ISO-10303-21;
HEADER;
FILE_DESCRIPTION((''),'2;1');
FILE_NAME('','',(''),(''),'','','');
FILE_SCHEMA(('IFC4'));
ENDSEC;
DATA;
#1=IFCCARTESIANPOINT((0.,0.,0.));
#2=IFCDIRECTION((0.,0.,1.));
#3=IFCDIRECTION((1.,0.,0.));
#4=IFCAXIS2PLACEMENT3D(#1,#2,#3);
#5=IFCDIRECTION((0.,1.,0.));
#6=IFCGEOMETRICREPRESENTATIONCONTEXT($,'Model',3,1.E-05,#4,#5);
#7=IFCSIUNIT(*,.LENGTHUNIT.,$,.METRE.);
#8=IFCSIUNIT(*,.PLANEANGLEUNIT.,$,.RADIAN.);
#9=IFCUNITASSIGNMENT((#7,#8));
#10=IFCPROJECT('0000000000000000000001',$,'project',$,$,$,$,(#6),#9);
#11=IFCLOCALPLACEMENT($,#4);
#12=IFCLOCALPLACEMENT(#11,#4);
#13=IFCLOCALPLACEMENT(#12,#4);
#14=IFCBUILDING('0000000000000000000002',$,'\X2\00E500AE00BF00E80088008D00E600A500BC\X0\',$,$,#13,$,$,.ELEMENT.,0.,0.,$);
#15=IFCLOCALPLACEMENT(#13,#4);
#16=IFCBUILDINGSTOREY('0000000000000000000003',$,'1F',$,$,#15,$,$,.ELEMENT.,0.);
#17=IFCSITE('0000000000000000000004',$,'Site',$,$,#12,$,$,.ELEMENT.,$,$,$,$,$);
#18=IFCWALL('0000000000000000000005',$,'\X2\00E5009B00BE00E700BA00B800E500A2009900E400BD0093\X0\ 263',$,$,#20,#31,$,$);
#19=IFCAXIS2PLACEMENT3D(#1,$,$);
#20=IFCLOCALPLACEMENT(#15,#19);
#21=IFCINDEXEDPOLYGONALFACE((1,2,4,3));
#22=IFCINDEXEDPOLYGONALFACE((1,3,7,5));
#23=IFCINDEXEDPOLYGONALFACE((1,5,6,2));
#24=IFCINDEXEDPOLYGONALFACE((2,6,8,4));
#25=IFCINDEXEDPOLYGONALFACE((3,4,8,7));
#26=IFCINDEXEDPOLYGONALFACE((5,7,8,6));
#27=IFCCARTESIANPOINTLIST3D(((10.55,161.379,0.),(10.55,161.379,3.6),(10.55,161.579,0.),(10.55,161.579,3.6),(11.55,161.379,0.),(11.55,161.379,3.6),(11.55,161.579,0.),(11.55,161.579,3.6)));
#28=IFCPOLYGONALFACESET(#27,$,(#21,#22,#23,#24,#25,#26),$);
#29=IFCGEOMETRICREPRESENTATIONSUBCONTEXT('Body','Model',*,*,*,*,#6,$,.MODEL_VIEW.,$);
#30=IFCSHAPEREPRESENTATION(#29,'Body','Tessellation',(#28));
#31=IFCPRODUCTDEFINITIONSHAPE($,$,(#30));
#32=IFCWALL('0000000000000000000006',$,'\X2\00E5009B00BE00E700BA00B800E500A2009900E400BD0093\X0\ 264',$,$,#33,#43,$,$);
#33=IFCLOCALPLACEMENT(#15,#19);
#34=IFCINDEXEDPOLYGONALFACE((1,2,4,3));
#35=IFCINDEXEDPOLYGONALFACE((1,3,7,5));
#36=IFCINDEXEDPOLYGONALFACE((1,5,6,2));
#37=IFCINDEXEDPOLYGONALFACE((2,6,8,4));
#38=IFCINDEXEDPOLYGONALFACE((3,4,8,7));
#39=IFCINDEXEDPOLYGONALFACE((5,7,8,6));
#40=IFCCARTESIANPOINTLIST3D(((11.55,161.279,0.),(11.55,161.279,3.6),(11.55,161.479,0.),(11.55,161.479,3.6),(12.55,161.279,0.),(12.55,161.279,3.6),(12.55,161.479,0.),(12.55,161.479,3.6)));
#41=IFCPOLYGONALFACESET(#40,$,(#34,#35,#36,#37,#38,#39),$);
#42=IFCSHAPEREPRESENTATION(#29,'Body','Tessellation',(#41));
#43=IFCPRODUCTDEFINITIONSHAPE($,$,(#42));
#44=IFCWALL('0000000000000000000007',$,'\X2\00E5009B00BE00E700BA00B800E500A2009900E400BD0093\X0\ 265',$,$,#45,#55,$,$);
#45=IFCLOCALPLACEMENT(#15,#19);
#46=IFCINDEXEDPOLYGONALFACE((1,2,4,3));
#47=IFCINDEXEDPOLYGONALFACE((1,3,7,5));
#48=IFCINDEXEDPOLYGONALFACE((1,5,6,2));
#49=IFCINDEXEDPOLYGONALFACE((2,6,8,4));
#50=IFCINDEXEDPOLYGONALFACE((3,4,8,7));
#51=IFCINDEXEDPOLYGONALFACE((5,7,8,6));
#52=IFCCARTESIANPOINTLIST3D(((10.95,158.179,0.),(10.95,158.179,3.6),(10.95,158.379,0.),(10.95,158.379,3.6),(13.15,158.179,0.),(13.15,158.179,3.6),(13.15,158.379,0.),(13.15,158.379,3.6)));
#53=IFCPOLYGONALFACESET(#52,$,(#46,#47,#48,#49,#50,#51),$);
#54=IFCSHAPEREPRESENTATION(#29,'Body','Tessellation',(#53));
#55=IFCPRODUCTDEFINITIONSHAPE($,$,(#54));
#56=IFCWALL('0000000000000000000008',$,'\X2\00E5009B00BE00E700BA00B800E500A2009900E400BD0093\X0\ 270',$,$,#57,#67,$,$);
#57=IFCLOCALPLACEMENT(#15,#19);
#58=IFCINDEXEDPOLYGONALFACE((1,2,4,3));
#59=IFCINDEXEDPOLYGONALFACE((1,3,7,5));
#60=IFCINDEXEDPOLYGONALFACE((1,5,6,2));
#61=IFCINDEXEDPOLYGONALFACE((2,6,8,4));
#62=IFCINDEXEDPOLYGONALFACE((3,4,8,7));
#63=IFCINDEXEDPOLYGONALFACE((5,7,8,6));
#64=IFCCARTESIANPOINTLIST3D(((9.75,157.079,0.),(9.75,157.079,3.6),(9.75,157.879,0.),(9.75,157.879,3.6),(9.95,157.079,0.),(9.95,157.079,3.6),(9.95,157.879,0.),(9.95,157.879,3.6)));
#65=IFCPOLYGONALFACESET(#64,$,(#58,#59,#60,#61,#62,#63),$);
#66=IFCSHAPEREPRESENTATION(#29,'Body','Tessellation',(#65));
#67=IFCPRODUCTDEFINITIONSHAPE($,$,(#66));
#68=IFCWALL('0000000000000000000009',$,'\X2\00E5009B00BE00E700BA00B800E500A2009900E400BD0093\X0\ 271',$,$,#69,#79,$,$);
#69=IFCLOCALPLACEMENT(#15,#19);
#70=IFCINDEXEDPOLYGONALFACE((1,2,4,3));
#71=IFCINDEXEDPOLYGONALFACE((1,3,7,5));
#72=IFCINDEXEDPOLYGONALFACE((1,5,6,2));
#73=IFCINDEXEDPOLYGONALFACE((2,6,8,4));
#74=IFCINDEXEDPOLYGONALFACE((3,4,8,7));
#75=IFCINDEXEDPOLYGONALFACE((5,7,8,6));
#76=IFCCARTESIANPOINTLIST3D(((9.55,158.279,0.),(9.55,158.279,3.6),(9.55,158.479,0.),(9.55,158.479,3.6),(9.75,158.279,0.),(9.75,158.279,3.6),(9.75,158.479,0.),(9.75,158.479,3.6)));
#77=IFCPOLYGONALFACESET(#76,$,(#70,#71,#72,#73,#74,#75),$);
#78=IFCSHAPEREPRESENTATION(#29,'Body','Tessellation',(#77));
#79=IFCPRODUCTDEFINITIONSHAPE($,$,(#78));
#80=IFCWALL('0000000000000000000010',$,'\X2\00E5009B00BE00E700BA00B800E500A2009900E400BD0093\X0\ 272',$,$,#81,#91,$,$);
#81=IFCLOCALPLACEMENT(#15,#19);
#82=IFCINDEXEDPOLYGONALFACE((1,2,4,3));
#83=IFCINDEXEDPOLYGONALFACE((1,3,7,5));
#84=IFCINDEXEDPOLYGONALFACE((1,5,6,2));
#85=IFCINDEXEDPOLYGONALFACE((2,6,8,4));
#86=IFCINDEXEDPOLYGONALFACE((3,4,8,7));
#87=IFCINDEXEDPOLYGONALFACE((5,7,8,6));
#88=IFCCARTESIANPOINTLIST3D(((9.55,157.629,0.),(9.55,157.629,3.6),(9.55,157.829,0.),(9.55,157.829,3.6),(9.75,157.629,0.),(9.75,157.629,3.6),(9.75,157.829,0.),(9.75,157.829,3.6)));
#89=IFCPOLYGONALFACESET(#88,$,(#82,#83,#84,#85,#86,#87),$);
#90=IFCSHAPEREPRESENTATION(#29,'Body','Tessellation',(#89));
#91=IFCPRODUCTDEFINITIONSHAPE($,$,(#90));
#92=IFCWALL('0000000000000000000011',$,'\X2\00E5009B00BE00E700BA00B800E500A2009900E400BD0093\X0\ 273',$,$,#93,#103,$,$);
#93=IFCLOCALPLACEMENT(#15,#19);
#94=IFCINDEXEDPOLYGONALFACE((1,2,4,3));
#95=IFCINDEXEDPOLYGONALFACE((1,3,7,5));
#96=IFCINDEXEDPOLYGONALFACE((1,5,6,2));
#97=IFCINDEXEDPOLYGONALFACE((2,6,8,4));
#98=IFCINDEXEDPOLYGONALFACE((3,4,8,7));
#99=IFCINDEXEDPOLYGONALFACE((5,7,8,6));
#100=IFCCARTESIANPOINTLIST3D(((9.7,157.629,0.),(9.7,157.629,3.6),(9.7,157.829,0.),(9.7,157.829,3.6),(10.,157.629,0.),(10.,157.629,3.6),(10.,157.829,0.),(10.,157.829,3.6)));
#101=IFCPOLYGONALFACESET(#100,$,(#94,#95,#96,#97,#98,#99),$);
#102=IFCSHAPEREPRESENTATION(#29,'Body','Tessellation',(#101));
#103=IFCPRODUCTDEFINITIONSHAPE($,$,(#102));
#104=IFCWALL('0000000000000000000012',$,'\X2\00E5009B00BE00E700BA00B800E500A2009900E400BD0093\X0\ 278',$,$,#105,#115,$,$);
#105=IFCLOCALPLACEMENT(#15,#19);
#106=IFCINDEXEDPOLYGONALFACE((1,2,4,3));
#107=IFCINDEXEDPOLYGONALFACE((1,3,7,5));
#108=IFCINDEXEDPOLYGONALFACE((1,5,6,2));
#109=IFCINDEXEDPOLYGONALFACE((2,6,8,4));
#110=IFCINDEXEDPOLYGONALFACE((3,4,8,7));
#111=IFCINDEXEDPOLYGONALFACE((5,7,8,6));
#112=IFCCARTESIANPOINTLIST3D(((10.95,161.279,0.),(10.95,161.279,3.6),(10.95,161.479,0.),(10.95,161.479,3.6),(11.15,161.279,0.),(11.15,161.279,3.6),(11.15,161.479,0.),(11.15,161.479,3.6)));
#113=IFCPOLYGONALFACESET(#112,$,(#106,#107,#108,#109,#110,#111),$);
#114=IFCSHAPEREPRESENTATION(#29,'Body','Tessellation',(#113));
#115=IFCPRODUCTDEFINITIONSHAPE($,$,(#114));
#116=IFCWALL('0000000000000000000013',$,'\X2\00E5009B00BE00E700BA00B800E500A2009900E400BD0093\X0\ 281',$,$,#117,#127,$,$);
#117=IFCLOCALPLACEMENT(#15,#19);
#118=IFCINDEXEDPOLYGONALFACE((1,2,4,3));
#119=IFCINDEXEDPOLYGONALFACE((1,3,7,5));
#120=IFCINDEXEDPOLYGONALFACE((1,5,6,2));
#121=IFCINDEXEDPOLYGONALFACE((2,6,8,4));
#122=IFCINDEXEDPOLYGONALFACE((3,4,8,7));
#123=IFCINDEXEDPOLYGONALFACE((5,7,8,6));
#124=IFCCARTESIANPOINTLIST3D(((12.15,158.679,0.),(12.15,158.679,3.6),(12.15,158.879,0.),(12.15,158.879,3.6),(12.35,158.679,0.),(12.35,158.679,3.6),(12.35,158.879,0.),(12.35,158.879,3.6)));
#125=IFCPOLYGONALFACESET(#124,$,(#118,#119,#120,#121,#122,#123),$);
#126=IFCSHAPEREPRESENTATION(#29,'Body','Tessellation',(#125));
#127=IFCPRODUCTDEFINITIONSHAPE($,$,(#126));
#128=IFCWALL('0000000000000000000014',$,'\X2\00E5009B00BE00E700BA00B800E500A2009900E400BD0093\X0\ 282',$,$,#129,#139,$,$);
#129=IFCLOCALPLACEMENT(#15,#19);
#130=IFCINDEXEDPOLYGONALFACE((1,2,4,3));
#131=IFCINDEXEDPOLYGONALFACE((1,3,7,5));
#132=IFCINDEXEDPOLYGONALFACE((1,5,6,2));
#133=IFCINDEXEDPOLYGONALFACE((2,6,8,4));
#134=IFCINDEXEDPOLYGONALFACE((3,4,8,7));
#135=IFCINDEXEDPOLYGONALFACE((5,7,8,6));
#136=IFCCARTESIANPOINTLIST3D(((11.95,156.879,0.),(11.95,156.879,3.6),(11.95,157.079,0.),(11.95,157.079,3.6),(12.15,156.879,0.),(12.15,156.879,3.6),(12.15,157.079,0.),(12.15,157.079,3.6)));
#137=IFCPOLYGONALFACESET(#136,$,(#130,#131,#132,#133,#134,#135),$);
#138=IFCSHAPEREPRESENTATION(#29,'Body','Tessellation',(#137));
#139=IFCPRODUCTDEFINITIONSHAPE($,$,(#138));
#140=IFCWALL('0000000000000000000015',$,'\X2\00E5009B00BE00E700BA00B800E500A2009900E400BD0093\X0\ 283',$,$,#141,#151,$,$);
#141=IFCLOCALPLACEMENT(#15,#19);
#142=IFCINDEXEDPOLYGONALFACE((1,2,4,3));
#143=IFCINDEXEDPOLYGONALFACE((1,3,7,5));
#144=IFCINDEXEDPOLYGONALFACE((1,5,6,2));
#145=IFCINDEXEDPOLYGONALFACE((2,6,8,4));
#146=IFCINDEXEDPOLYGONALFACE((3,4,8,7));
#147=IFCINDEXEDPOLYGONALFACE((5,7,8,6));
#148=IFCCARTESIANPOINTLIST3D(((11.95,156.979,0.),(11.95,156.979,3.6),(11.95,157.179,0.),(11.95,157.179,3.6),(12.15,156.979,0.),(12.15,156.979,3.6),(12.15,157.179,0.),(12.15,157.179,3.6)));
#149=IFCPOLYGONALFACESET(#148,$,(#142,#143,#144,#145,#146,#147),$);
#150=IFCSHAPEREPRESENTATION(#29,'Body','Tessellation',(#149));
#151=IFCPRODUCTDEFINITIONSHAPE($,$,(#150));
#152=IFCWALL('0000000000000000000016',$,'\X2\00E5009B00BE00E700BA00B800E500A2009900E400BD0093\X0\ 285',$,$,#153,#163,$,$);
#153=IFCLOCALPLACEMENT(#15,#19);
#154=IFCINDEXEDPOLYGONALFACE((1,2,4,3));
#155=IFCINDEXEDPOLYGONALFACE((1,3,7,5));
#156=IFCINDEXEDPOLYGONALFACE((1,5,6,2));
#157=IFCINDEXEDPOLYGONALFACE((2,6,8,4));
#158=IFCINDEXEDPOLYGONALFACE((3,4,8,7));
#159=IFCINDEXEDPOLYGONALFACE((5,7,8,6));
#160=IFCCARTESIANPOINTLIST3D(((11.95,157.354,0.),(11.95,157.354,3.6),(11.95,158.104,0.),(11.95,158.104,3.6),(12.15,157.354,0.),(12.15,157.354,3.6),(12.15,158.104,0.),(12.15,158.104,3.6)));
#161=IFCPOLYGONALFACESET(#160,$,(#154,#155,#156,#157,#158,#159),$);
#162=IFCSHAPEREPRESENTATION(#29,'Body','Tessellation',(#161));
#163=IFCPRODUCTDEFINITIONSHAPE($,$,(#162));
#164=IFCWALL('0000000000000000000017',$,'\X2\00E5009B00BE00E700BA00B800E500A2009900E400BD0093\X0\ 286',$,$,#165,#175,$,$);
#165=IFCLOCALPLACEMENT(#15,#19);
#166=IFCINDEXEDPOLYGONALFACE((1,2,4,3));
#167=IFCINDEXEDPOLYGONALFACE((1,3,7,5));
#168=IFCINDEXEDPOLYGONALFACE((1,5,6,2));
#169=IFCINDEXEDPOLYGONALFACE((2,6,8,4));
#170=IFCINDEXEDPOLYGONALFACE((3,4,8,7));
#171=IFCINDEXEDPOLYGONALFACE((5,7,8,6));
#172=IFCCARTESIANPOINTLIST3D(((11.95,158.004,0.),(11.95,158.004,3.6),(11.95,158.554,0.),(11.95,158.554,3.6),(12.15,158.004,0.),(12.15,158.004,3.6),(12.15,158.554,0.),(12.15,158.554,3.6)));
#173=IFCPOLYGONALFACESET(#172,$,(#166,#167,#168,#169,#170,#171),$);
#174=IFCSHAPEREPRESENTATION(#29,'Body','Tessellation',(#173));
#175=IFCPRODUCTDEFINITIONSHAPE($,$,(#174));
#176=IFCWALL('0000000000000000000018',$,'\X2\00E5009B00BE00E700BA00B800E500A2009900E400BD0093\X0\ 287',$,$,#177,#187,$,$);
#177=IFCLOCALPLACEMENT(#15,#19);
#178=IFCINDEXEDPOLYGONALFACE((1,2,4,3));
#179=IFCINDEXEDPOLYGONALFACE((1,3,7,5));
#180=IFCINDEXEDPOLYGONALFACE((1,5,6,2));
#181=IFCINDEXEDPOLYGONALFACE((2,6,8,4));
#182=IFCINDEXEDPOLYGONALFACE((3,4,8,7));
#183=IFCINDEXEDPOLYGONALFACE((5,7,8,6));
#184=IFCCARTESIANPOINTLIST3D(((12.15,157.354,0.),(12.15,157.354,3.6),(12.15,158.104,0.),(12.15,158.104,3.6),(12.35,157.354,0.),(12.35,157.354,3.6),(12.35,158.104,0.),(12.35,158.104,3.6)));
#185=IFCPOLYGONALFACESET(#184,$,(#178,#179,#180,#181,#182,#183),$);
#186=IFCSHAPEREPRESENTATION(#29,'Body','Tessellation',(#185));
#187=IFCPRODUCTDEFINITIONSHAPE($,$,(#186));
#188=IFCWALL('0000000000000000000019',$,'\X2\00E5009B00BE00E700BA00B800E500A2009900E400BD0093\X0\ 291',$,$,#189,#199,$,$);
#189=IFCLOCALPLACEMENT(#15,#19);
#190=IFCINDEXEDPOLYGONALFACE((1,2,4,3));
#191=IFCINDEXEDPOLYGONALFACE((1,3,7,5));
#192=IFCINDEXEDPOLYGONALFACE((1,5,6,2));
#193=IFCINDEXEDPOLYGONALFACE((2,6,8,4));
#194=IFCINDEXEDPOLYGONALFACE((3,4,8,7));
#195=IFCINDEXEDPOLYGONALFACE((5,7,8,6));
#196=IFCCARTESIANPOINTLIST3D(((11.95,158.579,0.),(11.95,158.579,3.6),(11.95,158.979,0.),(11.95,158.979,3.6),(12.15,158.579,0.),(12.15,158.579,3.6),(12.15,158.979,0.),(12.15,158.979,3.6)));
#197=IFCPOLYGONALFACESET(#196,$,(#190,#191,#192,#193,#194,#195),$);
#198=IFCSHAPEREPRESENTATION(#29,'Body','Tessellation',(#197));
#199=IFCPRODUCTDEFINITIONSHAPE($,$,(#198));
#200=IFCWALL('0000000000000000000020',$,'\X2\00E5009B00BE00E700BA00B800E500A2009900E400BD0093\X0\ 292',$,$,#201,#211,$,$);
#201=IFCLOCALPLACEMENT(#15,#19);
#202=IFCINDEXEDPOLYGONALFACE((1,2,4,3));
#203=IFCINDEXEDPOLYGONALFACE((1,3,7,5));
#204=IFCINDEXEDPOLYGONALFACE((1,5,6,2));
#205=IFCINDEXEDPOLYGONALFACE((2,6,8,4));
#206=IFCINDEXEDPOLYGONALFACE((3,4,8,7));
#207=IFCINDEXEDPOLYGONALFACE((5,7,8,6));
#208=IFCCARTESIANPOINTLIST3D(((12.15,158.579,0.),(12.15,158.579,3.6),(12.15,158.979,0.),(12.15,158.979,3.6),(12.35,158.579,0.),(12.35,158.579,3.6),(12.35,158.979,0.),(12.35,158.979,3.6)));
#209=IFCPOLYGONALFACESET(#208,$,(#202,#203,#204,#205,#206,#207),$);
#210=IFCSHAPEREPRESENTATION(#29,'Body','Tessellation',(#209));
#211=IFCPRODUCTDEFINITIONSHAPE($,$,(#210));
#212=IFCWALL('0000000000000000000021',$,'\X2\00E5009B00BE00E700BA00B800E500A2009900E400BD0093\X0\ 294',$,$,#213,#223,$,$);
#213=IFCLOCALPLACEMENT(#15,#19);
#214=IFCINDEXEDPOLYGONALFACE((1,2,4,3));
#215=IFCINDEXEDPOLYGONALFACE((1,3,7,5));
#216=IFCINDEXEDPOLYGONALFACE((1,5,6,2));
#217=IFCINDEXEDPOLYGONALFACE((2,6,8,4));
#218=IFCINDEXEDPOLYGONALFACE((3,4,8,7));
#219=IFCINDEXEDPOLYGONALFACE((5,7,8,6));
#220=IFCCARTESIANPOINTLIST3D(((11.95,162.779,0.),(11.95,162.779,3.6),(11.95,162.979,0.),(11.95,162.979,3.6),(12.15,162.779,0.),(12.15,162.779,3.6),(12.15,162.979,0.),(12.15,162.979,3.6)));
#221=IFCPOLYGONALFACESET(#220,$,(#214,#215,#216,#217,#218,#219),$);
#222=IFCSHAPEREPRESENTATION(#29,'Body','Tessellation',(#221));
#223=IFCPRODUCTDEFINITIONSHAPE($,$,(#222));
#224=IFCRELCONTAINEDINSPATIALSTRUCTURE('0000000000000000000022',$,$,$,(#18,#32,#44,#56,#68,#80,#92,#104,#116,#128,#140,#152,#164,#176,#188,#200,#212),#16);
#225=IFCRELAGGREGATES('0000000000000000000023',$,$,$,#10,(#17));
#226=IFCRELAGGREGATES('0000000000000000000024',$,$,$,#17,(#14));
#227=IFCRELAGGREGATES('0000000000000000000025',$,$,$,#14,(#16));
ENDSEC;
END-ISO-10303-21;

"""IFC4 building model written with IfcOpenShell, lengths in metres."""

from ifc_helpers import new_model, si_unit, direction, frame, frame_2d, origin_with_axes, place, context, subcontext, project, spatial, rectangle, extrude, element, save


model = new_model("IFC4")

# Units and contexts
model_context = context("Model", 3, precision=1e-05, world=origin_with_axes(), true_north=direction((0.0, 1.0, 0.0)))
body_context = subcontext(model_context, "Body", "Model", "MODEL_VIEW")
ifc_project = project(units=[si_unit("LENGTHUNIT", "METRE"), si_unit("PLANEANGLEUNIT", "RADIAN")], contexts=[model_context])

# Site, building, storey
placement = place(None, origin_with_axes())
site_placement = place(placement, origin_with_axes())
site = spatial("IfcSite", under=ifc_project, at=site_placement, Name="Site", CompositionType="ELEMENT")
building_placement = place(site_placement, origin_with_axes())
building = spatial("IfcBuilding", under=site, at=building_placement, Name="å®¿è\u0088\u008dæ¥¼", CompositionType="ELEMENT", ElevationOfRefHeight=0.0, ElevationOfTerrain=0.0)
storey_placement = place(building_placement, origin_with_axes())
storey = spatial("IfcBuildingStorey", under=building, at=storey_placement, Name="1F", CompositionType="ELEMENT", Elevation=0.0)

# Walls
for number, where, z_axis, x_axis, name in (
    (1, (11.05, 161.479, 0.0), (0.0, 0.0, 1.0), (1.0, 0.0, 0.0), "å\u009b¾çº¸å¢\u0099ä½\u0093 263"),
    (2, (12.05, 161.379, 0.0), (0.0, 0.0, 1.0), (-1.0, 0.0, 0.0), "å\u009b¾çº¸å¢\u0099ä½\u0093 264"),
):
    element("IfcWall", number, at=place(storey_placement, frame(where, z_axis=z_axis, x_axis=x_axis)), inside=storey, Name=name, context=body_context, shape_type="SweptSolid", body=[
        extrude(rectangle(XDim=1.0, YDim=0.2, at=frame_2d((0.0, 0.0), x_axis=(1.0, 0.0, 0.0))), frame((0.0, 0.0, 0.0), z_axis=(0.0, 0.0, 1.0)), (0.0, 0.0, 1.0), 3.6),
    ])
wall_1_placement = place(storey_placement, frame((12.05, 158.279, 0.0), z_axis=(0.0, 0.0, 1.0), x_axis=(-1.0, 0.0, 0.0)))
element("IfcWall", 3, at=wall_1_placement, inside=storey, Name="å\u009b¾çº¸å¢\u0099ä½\u0093 265", context=body_context, shape_type="SweptSolid", body=[
    extrude(rectangle(XDim=2.2, YDim=0.2, at=frame_2d((0.0, 0.0), x_axis=(1.0, 0.0, 0.0))), frame((0.0, 0.0, 0.0), z_axis=(0.0, 0.0, 1.0)), (0.0, 0.0, 1.0), 3.6),
])
wall_2_placement = place(storey_placement, frame((9.85, 157.479, 0.0), z_axis=(0.0, 0.0, 1.0), x_axis=(0.0, 1.0, 0.0)))
element("IfcWall", 4, at=wall_2_placement, inside=storey, Name="å\u009b¾çº¸å¢\u0099ä½\u0093 270", context=body_context, shape_type="SweptSolid", body=[
    extrude(rectangle(XDim=0.8, YDim=0.2, at=frame_2d((0.0, 0.0), x_axis=(1.0, 0.0, 0.0))), frame((0.0, 0.0, 0.0), z_axis=(0.0, 0.0, 1.0)), (0.0, 0.0, 1.0), 3.6),
])
for number, where, z_axis, x_axis, name in (
    (5, (9.65, 158.379, 0.0), (0.0, 0.0, 1.0), (1.0, 0.0, 0.0), "å\u009b¾çº¸å¢\u0099ä½\u0093 271"),
    (6, (9.65, 157.729, 0.0), (0.0, 0.0, 1.0), (1.0, 0.0, 0.0), "å\u009b¾çº¸å¢\u0099ä½\u0093 272"),
):
    element("IfcWall", number, at=place(storey_placement, frame(where, z_axis=z_axis, x_axis=x_axis)), inside=storey, Name=name, context=body_context, shape_type="SweptSolid", body=[
        extrude(rectangle(XDim=0.2, YDim=0.2, at=frame_2d((0.0, 0.0), x_axis=(1.0, 0.0, 0.0))), frame((0.0, 0.0, 0.0), z_axis=(0.0, 0.0, 1.0)), (0.0, 0.0, 1.0), 3.6),
    ])
wall_3_placement = place(storey_placement, frame((9.85, 157.729, 0.0), z_axis=(0.0, 0.0, 1.0), x_axis=(-1.0, 0.0, 0.0)))
element("IfcWall", 7, at=wall_3_placement, inside=storey, Name="å\u009b¾çº¸å¢\u0099ä½\u0093 273", context=body_context, shape_type="SweptSolid", body=[
    extrude(rectangle(XDim=0.3, YDim=0.2, at=frame_2d((0.0, 0.0), x_axis=(1.0, 0.0, 0.0))), frame((0.0, 0.0, 0.0), z_axis=(0.0, 0.0, 1.0)), (0.0, 0.0, 1.0), 3.6),
])
for number, where, z_axis, x_axis, name in (
    (8, (11.05, 161.379, 0.0), (0.0, 0.0, 1.0), (0.0, 1.0, 0.0), "å\u009b¾çº¸å¢\u0099ä½\u0093 278"),
    (9, (12.25, 158.779, 0.0), (0.0, 0.0, 1.0), (-1.0, 0.0, 0.0), "å\u009b¾çº¸å¢\u0099ä½\u0093 281"),
    (10, (12.05, 156.979, 0.0), (0.0, 0.0, 1.0), (1.0, 0.0, 0.0), "å\u009b¾çº¸å¢\u0099ä½\u0093 282"),
    (11, (12.05, 157.079, 0.0), (0.0, 0.0, 1.0), (1.0, 0.0, 0.0), "å\u009b¾çº¸å¢\u0099ä½\u0093 283"),
):
    element("IfcWall", number, at=place(storey_placement, frame(where, z_axis=z_axis, x_axis=x_axis)), inside=storey, Name=name, context=body_context, shape_type="SweptSolid", body=[
        extrude(rectangle(XDim=0.2, YDim=0.2, at=frame_2d((0.0, 0.0), x_axis=(1.0, 0.0, 0.0))), frame((0.0, 0.0, 0.0), z_axis=(0.0, 0.0, 1.0)), (0.0, 0.0, 1.0), 3.6),
    ])
wall_4_placement = place(storey_placement, frame((12.05, 157.729, 0.0), z_axis=(0.0, 0.0, 1.0), x_axis=(0.0, -1.0, 0.0)))
element("IfcWall", 12, at=wall_4_placement, inside=storey, Name="å\u009b¾çº¸å¢\u0099ä½\u0093 285", context=body_context, shape_type="SweptSolid", body=[
    extrude(rectangle(XDim=0.75, YDim=0.2, at=frame_2d((0.0, 0.0), x_axis=(1.0, 0.0, 0.0))), frame((0.0, 0.0, 0.0), z_axis=(0.0, 0.0, 1.0)), (0.0, 0.0, 1.0), 3.6),
])
wall_5_placement = place(storey_placement, frame((12.05, 158.279, 0.0), z_axis=(0.0, 0.0, 1.0), x_axis=(0.0, -1.0, 0.0)))
element("IfcWall", 13, at=wall_5_placement, inside=storey, Name="å\u009b¾çº¸å¢\u0099ä½\u0093 286", context=body_context, shape_type="SweptSolid", body=[
    extrude(rectangle(XDim=0.55, YDim=0.2, at=frame_2d((0.0, 0.0), x_axis=(1.0, 0.0, 0.0))), frame((0.0, 0.0, 0.0), z_axis=(0.0, 0.0, 1.0)), (0.0, 0.0, 1.0), 3.6),
])
wall_6_placement = place(storey_placement, frame((12.25, 157.729, 0.0), z_axis=(0.0, 0.0, 1.0), x_axis=(0.0, -1.0, 0.0)))
element("IfcWall", 14, at=wall_6_placement, inside=storey, Name="å\u009b¾çº¸å¢\u0099ä½\u0093 287", context=body_context, shape_type="SweptSolid", body=[
    extrude(rectangle(XDim=0.75, YDim=0.2, at=frame_2d((0.0, 0.0), x_axis=(1.0, 0.0, 0.0))), frame((0.0, 0.0, 0.0), z_axis=(0.0, 0.0, 1.0)), (0.0, 0.0, 1.0), 3.6),
])
for number, where, z_axis, x_axis, name in (
    (15, (12.05, 158.779, 0.0), (0.0, 0.0, 1.0), (0.0, -1.0, 0.0), "å\u009b¾çº¸å¢\u0099ä½\u0093 291"),
    (16, (12.25, 158.779, 0.0), (0.0, 0.0, 1.0), (0.0, -1.0, 0.0), "å\u009b¾çº¸å¢\u0099ä½\u0093 292"),
):
    element("IfcWall", number, at=place(storey_placement, frame(where, z_axis=z_axis, x_axis=x_axis)), inside=storey, Name=name, context=body_context, shape_type="SweptSolid", body=[
        extrude(rectangle(XDim=0.4, YDim=0.2, at=frame_2d((0.0, 0.0), x_axis=(1.0, 0.0, 0.0))), frame((0.0, 0.0, 0.0), z_axis=(0.0, 0.0, 1.0)), (0.0, 0.0, 1.0), 3.6),
    ])
for number, where, z_axis, x_axis, name in (
    (17, (12.05, 162.879, 0.0), (0.0, 0.0, 1.0), (1.0, 0.0, 0.0), "å\u009b¾çº¸å¢\u0099ä½\u0093 294"),
):
    element("IfcWall", number, at=place(storey_placement, frame(where, z_axis=z_axis, x_axis=x_axis)), inside=storey, Name=name, context=body_context, shape_type="SweptSolid", body=[
        extrude(rectangle(XDim=0.2, YDim=0.2, at=frame_2d((0.0, 0.0), x_axis=(1.0, 0.0, 0.0))), frame((0.0, 0.0, 0.0), z_axis=(0.0, 0.0, 1.0)), (0.0, 0.0, 1.0), 3.6),
    ])

save(model, "model.ifc")
